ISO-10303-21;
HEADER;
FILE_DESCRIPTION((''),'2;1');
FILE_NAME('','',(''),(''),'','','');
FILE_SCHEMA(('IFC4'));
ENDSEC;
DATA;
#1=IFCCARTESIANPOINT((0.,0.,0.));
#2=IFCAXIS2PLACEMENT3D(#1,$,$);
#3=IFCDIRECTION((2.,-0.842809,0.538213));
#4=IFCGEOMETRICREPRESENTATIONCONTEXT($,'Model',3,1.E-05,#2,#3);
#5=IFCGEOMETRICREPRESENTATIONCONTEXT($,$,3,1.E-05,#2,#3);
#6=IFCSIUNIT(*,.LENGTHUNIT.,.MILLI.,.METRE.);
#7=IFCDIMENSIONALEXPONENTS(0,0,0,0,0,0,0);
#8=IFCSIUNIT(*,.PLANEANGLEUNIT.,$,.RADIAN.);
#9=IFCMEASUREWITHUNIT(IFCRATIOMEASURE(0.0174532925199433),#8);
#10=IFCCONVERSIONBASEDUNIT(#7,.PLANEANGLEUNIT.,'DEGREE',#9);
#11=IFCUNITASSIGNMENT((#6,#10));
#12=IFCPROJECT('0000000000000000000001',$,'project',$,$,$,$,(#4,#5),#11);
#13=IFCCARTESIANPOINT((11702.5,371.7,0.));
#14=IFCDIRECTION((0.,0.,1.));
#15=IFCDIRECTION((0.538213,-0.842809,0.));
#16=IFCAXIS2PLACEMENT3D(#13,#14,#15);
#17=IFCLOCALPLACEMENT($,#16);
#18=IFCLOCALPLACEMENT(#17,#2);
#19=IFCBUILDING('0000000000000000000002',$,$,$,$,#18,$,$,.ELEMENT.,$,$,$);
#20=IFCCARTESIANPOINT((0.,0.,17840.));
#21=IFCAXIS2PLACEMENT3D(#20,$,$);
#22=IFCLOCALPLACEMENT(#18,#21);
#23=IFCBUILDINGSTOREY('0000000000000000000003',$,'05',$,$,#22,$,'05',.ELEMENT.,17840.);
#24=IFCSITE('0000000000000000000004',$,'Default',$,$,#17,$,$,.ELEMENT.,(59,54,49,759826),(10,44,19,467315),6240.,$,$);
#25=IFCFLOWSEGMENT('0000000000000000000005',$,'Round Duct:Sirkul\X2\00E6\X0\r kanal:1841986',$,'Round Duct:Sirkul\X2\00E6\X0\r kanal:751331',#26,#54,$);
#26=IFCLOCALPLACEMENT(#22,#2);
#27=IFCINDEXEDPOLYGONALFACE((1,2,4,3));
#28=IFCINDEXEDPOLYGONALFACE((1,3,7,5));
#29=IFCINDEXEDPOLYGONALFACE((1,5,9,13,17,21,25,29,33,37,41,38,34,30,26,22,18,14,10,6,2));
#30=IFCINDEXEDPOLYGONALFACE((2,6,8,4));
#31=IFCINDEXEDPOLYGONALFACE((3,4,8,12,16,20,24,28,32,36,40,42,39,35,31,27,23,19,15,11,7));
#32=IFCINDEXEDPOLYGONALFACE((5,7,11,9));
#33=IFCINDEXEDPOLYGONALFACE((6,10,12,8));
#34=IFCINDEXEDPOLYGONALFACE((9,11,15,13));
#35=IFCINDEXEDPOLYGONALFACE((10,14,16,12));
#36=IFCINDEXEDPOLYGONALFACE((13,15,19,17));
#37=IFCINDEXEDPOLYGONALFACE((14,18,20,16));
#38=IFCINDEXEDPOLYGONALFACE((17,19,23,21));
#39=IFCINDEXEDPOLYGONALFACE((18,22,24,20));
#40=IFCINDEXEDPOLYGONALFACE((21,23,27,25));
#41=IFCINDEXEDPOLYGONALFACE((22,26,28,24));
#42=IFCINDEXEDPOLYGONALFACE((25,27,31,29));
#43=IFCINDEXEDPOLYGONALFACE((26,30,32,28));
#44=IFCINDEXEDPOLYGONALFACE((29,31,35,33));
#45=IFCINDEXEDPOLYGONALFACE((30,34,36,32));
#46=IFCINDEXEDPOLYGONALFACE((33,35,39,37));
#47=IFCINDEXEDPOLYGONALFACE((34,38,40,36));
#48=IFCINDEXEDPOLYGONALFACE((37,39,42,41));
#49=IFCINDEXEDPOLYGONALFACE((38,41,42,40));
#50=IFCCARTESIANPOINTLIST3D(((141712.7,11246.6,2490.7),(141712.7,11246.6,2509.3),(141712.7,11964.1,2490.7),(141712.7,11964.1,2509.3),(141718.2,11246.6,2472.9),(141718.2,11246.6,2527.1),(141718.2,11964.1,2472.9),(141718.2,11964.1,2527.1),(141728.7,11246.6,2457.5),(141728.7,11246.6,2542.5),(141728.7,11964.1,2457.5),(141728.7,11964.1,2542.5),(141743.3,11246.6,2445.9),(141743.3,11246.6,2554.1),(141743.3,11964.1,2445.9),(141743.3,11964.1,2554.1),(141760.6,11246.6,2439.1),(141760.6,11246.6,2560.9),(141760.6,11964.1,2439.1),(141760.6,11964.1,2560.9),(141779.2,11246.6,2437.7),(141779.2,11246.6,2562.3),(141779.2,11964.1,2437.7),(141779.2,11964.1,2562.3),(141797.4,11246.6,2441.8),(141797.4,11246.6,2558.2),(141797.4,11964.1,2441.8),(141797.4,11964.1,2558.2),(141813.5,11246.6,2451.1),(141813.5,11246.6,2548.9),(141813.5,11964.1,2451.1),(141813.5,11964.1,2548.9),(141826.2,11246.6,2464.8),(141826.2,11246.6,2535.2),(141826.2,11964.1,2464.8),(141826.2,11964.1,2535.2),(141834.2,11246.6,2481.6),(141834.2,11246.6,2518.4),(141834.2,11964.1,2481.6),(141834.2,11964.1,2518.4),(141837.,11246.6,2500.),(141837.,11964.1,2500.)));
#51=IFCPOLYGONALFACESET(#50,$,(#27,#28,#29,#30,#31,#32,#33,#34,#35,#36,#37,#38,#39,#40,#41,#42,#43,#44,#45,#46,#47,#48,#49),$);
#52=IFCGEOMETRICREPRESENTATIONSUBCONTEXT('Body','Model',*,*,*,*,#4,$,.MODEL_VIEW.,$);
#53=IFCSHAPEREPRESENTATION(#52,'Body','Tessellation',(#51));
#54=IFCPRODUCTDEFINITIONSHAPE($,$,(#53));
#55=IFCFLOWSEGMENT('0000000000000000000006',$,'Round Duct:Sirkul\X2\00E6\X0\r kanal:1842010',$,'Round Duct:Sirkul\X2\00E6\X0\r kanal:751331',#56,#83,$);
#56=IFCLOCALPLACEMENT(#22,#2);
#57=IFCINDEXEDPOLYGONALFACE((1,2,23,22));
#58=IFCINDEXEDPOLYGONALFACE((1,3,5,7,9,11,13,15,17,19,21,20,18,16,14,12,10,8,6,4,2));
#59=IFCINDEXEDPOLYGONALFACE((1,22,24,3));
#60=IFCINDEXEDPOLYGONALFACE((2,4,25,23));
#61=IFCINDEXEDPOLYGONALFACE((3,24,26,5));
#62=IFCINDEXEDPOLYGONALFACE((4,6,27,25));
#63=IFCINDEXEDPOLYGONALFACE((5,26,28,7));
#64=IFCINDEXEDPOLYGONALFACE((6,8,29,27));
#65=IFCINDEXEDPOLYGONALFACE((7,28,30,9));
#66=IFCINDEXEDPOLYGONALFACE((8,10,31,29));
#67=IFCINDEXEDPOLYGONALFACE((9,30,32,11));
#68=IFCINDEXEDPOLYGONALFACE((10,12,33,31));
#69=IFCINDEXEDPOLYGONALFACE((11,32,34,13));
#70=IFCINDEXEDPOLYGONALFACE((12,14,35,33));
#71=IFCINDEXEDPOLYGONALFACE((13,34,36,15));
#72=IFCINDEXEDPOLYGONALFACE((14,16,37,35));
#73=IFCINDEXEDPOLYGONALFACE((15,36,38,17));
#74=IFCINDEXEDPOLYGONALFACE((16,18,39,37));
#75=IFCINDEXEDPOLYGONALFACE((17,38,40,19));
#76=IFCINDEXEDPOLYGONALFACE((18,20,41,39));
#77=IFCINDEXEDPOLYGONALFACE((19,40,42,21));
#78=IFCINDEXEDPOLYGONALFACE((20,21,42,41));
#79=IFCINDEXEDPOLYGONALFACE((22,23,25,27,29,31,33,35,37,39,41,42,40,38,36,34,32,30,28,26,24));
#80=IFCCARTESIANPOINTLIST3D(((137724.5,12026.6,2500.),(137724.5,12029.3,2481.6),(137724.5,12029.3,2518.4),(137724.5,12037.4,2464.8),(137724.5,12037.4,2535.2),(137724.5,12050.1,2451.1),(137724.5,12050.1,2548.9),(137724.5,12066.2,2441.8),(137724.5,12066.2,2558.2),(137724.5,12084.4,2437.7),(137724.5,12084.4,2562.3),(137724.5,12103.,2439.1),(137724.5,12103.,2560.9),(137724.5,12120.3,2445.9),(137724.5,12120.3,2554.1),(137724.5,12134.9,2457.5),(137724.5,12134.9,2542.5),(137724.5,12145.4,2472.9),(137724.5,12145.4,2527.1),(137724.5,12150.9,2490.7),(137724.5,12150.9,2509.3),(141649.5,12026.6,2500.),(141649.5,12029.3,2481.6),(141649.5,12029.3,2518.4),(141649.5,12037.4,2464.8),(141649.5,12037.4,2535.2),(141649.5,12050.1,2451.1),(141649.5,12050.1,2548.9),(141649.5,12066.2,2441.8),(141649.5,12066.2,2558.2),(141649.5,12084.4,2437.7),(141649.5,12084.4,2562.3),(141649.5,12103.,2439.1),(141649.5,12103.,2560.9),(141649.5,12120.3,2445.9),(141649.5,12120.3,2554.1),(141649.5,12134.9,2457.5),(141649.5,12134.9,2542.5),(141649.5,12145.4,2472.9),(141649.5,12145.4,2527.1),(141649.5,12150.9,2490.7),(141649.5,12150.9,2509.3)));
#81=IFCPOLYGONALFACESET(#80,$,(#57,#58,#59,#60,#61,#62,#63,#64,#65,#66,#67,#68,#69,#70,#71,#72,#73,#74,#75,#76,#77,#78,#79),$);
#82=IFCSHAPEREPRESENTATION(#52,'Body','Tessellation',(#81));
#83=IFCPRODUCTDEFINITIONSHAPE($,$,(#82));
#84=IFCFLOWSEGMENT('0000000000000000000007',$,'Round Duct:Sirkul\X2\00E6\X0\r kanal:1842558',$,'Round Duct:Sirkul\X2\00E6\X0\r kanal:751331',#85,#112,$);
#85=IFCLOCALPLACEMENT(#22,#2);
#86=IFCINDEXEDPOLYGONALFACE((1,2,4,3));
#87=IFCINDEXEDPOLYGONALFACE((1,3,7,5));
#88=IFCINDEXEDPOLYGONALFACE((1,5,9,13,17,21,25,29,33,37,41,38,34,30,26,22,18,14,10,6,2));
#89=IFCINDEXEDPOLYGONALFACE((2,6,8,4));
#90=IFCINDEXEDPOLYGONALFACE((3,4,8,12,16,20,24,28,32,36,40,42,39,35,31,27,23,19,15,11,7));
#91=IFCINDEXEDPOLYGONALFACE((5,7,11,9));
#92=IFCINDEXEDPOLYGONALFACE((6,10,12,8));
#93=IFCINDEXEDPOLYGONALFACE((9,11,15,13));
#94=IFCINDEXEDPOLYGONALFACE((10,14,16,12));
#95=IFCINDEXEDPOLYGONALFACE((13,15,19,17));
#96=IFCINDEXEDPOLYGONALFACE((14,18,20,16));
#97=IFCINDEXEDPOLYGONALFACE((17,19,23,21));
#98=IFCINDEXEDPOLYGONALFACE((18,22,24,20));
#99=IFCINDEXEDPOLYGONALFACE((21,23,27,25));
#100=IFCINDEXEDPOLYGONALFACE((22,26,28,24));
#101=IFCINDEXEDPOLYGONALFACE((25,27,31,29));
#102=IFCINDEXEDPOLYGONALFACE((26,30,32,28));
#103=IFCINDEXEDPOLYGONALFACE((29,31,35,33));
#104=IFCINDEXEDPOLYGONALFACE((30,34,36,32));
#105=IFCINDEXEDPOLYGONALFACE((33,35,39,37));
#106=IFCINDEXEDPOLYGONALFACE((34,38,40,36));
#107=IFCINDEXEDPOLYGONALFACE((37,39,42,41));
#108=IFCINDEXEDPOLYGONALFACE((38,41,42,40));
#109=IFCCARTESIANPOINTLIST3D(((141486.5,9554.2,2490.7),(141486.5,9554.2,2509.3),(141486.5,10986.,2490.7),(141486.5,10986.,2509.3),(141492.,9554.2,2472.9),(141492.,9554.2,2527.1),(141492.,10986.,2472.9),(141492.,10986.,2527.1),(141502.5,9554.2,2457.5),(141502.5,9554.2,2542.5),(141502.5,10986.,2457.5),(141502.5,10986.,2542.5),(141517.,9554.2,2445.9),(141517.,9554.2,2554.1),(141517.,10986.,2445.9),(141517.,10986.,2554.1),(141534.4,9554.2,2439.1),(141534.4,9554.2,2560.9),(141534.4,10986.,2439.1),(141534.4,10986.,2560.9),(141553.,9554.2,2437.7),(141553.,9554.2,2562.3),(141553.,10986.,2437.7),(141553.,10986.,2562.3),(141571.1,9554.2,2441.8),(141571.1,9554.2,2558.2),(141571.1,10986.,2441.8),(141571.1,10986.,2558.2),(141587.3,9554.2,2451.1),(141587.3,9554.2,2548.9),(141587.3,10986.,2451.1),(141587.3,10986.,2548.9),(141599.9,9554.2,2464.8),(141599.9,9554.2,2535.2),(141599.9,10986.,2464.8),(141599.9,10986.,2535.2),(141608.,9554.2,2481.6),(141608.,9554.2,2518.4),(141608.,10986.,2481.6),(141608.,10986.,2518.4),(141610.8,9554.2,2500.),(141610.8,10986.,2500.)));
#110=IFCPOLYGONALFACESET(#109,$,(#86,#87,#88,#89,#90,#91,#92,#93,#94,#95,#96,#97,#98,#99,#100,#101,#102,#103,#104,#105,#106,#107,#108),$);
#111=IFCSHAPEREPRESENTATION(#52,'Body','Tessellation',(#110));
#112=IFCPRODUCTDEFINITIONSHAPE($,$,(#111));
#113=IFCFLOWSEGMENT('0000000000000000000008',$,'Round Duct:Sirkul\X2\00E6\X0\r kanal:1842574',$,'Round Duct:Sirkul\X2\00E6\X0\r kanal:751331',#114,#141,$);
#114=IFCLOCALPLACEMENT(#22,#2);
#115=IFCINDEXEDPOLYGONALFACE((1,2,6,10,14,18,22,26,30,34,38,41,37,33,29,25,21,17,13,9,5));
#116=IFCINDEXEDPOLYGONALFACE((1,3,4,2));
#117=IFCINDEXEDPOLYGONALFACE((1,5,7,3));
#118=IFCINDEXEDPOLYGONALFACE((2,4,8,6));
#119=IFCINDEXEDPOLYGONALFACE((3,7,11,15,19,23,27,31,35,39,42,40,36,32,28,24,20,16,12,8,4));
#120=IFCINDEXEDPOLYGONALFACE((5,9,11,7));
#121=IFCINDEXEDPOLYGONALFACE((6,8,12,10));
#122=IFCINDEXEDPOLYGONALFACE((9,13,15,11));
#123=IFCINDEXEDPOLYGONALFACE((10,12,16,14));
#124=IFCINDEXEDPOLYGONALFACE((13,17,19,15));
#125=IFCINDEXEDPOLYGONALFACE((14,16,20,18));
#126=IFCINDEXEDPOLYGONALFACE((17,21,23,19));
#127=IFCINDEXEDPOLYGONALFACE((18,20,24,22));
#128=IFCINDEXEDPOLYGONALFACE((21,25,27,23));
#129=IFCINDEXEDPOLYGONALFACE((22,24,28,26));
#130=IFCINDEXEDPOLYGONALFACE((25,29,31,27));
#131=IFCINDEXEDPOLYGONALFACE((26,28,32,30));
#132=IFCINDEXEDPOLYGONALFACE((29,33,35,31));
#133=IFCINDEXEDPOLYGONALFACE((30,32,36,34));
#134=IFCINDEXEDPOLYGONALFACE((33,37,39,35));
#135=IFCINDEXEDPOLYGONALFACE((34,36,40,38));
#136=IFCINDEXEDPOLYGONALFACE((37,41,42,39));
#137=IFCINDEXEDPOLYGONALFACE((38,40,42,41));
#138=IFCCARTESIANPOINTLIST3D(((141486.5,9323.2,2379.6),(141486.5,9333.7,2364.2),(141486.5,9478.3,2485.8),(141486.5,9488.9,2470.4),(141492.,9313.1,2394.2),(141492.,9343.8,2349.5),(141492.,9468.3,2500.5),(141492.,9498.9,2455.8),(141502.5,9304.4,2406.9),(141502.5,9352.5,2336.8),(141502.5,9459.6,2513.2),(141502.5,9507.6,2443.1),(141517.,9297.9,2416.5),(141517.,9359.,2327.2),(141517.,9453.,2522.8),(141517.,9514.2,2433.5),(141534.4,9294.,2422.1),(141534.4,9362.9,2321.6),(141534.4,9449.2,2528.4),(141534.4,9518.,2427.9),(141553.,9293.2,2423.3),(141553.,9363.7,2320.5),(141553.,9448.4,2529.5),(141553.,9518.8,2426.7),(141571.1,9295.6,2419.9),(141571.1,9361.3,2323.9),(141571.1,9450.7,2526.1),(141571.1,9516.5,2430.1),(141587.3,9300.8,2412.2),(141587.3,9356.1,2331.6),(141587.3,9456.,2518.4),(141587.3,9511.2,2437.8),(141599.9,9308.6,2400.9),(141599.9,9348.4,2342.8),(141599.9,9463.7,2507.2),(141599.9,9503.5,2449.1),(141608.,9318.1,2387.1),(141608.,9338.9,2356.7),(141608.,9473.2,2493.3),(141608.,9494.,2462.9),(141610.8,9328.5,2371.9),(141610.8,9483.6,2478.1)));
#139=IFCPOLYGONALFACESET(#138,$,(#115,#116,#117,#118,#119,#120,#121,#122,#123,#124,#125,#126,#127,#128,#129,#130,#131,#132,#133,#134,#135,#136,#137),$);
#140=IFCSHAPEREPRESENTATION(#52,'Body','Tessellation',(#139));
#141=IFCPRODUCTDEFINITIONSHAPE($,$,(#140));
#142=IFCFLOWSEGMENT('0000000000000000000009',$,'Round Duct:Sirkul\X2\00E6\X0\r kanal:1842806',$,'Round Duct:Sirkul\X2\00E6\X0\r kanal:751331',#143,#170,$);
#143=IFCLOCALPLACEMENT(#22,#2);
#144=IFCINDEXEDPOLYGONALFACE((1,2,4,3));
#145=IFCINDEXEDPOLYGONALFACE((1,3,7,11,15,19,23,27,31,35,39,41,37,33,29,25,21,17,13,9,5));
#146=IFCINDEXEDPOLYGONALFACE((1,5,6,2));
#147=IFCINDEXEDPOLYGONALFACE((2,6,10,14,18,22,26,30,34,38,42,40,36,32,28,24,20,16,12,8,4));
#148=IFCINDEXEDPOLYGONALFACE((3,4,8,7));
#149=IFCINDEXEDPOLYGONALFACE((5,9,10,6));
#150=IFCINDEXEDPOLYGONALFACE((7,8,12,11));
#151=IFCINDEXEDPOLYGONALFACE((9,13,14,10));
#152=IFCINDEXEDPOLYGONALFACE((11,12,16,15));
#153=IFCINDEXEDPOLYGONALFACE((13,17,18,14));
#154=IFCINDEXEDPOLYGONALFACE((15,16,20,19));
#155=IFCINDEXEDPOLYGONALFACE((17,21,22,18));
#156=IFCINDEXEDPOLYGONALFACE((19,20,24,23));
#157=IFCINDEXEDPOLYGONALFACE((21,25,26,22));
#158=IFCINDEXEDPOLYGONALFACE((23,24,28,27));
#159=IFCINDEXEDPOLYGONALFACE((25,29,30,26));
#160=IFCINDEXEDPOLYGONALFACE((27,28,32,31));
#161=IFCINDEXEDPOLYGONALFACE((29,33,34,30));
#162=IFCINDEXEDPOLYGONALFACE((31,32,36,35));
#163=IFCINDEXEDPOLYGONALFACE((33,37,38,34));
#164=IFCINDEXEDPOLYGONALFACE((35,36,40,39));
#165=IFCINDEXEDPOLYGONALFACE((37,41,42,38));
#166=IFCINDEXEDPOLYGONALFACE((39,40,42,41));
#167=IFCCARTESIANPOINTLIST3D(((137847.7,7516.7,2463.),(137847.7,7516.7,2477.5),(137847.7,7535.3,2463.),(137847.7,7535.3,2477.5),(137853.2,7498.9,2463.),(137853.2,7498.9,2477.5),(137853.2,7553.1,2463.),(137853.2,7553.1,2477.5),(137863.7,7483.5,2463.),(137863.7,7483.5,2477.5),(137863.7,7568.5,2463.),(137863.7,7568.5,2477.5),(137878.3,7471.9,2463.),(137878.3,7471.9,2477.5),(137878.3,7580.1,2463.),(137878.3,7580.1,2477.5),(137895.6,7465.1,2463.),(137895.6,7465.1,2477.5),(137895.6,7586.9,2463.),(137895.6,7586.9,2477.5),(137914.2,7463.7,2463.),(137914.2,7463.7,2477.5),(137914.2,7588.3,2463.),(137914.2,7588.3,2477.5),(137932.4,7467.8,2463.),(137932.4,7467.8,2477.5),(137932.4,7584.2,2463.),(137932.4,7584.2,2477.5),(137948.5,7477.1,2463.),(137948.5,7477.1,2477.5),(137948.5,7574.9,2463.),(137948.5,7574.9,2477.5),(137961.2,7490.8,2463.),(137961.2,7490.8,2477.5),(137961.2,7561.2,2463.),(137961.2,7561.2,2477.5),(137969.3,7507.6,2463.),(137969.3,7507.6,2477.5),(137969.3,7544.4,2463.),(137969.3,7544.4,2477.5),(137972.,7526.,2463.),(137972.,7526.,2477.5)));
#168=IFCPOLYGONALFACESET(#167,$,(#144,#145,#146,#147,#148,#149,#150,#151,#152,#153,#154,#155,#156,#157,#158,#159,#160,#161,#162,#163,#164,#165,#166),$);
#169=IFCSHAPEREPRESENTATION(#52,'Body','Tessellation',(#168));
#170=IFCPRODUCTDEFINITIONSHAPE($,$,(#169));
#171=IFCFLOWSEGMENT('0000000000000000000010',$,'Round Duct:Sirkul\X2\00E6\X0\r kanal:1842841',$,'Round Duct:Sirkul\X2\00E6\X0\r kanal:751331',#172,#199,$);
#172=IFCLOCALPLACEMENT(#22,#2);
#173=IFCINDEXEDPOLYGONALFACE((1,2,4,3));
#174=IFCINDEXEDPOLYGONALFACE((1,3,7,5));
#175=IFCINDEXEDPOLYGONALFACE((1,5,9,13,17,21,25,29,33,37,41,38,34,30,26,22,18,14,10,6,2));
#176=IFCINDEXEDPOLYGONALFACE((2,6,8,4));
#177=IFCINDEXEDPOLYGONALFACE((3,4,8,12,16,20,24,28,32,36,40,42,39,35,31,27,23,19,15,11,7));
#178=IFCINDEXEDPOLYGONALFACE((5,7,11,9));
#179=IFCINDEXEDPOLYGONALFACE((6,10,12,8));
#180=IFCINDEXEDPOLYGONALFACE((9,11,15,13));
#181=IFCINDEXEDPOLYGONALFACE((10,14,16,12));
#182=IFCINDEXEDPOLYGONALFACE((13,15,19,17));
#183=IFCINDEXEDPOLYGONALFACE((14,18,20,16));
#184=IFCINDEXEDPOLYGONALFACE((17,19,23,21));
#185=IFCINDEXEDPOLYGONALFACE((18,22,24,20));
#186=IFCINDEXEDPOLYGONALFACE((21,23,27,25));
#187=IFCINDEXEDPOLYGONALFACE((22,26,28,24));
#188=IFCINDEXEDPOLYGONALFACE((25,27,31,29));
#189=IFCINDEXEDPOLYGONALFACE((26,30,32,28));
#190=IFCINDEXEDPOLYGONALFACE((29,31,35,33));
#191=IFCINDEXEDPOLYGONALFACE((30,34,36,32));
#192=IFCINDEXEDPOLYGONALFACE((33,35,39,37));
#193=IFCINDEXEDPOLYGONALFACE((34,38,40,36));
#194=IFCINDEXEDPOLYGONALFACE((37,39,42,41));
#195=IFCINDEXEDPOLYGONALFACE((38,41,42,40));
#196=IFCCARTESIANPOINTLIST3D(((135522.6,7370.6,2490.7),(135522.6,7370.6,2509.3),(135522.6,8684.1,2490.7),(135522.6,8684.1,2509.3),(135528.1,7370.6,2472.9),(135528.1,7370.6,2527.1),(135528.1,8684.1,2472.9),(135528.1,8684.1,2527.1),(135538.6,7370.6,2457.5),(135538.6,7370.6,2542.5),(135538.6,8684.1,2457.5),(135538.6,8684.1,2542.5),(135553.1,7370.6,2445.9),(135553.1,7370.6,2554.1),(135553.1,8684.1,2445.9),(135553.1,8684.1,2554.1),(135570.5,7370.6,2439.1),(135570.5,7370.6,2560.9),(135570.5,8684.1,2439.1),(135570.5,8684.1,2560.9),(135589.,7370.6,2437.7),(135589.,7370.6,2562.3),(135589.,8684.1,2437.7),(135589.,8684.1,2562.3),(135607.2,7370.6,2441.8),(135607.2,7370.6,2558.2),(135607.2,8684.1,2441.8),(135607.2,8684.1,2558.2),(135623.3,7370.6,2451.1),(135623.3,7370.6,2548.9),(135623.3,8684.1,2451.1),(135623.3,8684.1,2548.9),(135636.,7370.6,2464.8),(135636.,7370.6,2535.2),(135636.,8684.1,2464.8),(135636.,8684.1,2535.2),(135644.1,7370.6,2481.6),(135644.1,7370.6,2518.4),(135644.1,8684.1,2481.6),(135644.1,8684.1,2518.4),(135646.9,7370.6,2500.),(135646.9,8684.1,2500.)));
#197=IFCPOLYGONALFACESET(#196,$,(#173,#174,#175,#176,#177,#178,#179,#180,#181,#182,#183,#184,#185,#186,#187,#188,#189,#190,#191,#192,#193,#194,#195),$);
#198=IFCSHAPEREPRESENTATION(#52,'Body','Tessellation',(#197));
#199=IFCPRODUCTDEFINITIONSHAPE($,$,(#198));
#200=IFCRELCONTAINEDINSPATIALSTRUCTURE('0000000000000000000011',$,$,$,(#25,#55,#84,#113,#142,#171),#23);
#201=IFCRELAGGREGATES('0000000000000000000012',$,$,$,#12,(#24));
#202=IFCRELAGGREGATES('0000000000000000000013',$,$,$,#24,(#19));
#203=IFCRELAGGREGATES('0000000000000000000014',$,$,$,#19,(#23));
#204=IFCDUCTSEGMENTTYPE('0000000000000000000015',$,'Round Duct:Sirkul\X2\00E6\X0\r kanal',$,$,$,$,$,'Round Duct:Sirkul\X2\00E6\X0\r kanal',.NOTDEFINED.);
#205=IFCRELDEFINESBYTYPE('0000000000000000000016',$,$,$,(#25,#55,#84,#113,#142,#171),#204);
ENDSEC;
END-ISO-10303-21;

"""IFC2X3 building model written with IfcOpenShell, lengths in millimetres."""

from ifc_helpers import new_model, entity, si_unit, converted_unit, direction, frame, frame_2d, origin, origin_2d_with_axis, place, context, subcontext, project, spatial, circle, extrude, type_object, element, save


model = new_model("IFC2X3")

# Units and contexts
model_context = context("Model", 3, precision=1e-05, world=origin(), true_north=direction((2.0, -0.842809, 0.538213)))
context_of_model = context(None, 3, precision=1e-05, world=origin(), true_north=direction((2.0, -0.842809, 0.538213)))
body_context = subcontext(model_context, "Body", "Model", "MODEL_VIEW")
ifc_project = project(units=[si_unit("LENGTHUNIT", "METRE", prefix="MILLI"), converted_unit("PLANEANGLEUNIT", "DEGREE", entity("IfcRatioMeasure", 0.0174532925199433), si_unit("PLANEANGLEUNIT", "RADIAN"), dimensions=[0, 0, 0, 0, 0, 0, 0])], contexts=[model_context, context_of_model])

# Site, building, storey
site_placement = place(None, frame((11702.5, 371.7, 0.0), z_axis=(0.0, 0.0, 1.0), x_axis=(0.538213, -0.842809, 0.0)))
site = spatial("IfcSite", under=ifc_project, at=site_placement, Name="Default", CompositionType="ELEMENT", RefLatitude=(59, 54, 49, 759826), RefLongitude=(10, 44, 19, 467315), RefElevation=6240.0)
building_placement = place(site_placement, origin())
building = spatial("IfcBuilding", under=site, at=building_placement, CompositionType="ELEMENT")
storey_placement = place(building_placement, frame((0.0, 0.0, 17840.0)))
storey = spatial("IfcBuildingStorey", under=building, at=storey_placement, Name="05", LongName="05", CompositionType="ELEMENT", Elevation=17840.0)

# Flow segments
duct_segment_type_1 = type_object("IfcDuctSegmentType", Name="Round Duct:Sirkulær kanal", ElementType="Round Duct:Sirkulær kanal", PredefinedType="NOTDEFINED")
flow_segment_1_placement = place(storey_placement, origin())
element("IfcFlowSegment", 1, at=flow_segment_1_placement, inside=storey, type_object=duct_segment_type_1, Name="Round Duct:Sirkulær kanal:1841986", ObjectType="Round Duct:Sirkulær kanal:751331", context=body_context, shape_type="SweptSolid", body=[
    extrude(circle(Radius=62.5, at=origin_2d_with_axis()), frame((141774.5, 11246.6, 2500.0), z_axis=(0.0, 1.0, 0.0), x_axis=(1.0, 0.0, 0.0)), (0.0, 0.0, 1.0), 717.5),
])
flow_segment_2_placement = place(storey_placement, origin())
element("IfcFlowSegment", 2, at=flow_segment_2_placement, inside=storey, type_object=duct_segment_type_1, Name="Round Duct:Sirkulær kanal:1842010", ObjectType="Round Duct:Sirkulær kanal:751331", context=body_context, shape_type="SweptSolid", body=[
    extrude(circle(Radius=62.5, at=origin_2d_with_axis()), frame((137724.5, 12089.1, 2500.0), z_axis=(1.0, 0.0, 0.0), x_axis=(0.0, -1.0, 0.0)), (0.0, 0.0, 1.0), 3925.0),
])
flow_segment_3_placement = place(storey_placement, origin())
element("IfcFlowSegment", 3, at=flow_segment_3_placement, inside=storey, type_object=duct_segment_type_1, Name="Round Duct:Sirkulær kanal:1842558", ObjectType="Round Duct:Sirkulær kanal:751331", context=body_context, shape_type="SweptSolid", body=[
    extrude(circle(Radius=62.5, at=origin_2d_with_axis()), frame((141548.3, 9554.2, 2500.0), z_axis=(0.0, 1.0, 0.0), x_axis=(1.0, 0.0, 0.0)), (0.0, 0.0, 1.0), 1431.8),
])
flow_segment_4_placement = place(storey_placement, origin())
element("IfcFlowSegment", 4, at=flow_segment_4_placement, inside=storey, type_object=duct_segment_type_1, Name="Round Duct:Sirkulær kanal:1842574", ObjectType="Round Duct:Sirkulær kanal:751331", context=body_context, shape_type="SweptSolid", body=[
    extrude(circle(Radius=62.5, at=origin_2d_with_axis()), frame((141548.3, 9328.5, 2371.9), z_axis=(0.0, 0.82503, 0.565089), x_axis=(1.0, 0.0, 0.0)), (0.0, 0.0, 1.0), 188.0),
])
flow_segment_5_placement = place(storey_placement, origin())
element("IfcFlowSegment", 5, at=flow_segment_5_placement, inside=storey, type_object=duct_segment_type_1, Name="Round Duct:Sirkulær kanal:1842806", ObjectType="Round Duct:Sirkulær kanal:751331", context=body_context, shape_type="SweptSolid", body=[
    extrude(circle(Radius=62.5, at=frame_2d((0.0, 0.0), x_axis=(1.0, 0.0))), frame((137909.5, 7526.0, 2463.0)), (0.0, 0.0, 1.0), 14.5),
])
flow_segment_6_placement = place(storey_placement, origin())
element("IfcFlowSegment", 6, at=flow_segment_6_placement, inside=storey, type_object=duct_segment_type_1, Name="Round Duct:Sirkulær kanal:1842841", ObjectType="Round Duct:Sirkulær kanal:751331", context=body_context, shape_type="SweptSolid", body=[
    extrude(circle(Radius=62.5, at=origin_2d_with_axis()), frame((135584.4, 7370.6, 2500.0), z_axis=(0.0, 1.0, 0.0), x_axis=(1.0, 0.0, 0.0)), (0.0, 0.0, 1.0), 1313.5),
])

save(model, "model.ifc")
